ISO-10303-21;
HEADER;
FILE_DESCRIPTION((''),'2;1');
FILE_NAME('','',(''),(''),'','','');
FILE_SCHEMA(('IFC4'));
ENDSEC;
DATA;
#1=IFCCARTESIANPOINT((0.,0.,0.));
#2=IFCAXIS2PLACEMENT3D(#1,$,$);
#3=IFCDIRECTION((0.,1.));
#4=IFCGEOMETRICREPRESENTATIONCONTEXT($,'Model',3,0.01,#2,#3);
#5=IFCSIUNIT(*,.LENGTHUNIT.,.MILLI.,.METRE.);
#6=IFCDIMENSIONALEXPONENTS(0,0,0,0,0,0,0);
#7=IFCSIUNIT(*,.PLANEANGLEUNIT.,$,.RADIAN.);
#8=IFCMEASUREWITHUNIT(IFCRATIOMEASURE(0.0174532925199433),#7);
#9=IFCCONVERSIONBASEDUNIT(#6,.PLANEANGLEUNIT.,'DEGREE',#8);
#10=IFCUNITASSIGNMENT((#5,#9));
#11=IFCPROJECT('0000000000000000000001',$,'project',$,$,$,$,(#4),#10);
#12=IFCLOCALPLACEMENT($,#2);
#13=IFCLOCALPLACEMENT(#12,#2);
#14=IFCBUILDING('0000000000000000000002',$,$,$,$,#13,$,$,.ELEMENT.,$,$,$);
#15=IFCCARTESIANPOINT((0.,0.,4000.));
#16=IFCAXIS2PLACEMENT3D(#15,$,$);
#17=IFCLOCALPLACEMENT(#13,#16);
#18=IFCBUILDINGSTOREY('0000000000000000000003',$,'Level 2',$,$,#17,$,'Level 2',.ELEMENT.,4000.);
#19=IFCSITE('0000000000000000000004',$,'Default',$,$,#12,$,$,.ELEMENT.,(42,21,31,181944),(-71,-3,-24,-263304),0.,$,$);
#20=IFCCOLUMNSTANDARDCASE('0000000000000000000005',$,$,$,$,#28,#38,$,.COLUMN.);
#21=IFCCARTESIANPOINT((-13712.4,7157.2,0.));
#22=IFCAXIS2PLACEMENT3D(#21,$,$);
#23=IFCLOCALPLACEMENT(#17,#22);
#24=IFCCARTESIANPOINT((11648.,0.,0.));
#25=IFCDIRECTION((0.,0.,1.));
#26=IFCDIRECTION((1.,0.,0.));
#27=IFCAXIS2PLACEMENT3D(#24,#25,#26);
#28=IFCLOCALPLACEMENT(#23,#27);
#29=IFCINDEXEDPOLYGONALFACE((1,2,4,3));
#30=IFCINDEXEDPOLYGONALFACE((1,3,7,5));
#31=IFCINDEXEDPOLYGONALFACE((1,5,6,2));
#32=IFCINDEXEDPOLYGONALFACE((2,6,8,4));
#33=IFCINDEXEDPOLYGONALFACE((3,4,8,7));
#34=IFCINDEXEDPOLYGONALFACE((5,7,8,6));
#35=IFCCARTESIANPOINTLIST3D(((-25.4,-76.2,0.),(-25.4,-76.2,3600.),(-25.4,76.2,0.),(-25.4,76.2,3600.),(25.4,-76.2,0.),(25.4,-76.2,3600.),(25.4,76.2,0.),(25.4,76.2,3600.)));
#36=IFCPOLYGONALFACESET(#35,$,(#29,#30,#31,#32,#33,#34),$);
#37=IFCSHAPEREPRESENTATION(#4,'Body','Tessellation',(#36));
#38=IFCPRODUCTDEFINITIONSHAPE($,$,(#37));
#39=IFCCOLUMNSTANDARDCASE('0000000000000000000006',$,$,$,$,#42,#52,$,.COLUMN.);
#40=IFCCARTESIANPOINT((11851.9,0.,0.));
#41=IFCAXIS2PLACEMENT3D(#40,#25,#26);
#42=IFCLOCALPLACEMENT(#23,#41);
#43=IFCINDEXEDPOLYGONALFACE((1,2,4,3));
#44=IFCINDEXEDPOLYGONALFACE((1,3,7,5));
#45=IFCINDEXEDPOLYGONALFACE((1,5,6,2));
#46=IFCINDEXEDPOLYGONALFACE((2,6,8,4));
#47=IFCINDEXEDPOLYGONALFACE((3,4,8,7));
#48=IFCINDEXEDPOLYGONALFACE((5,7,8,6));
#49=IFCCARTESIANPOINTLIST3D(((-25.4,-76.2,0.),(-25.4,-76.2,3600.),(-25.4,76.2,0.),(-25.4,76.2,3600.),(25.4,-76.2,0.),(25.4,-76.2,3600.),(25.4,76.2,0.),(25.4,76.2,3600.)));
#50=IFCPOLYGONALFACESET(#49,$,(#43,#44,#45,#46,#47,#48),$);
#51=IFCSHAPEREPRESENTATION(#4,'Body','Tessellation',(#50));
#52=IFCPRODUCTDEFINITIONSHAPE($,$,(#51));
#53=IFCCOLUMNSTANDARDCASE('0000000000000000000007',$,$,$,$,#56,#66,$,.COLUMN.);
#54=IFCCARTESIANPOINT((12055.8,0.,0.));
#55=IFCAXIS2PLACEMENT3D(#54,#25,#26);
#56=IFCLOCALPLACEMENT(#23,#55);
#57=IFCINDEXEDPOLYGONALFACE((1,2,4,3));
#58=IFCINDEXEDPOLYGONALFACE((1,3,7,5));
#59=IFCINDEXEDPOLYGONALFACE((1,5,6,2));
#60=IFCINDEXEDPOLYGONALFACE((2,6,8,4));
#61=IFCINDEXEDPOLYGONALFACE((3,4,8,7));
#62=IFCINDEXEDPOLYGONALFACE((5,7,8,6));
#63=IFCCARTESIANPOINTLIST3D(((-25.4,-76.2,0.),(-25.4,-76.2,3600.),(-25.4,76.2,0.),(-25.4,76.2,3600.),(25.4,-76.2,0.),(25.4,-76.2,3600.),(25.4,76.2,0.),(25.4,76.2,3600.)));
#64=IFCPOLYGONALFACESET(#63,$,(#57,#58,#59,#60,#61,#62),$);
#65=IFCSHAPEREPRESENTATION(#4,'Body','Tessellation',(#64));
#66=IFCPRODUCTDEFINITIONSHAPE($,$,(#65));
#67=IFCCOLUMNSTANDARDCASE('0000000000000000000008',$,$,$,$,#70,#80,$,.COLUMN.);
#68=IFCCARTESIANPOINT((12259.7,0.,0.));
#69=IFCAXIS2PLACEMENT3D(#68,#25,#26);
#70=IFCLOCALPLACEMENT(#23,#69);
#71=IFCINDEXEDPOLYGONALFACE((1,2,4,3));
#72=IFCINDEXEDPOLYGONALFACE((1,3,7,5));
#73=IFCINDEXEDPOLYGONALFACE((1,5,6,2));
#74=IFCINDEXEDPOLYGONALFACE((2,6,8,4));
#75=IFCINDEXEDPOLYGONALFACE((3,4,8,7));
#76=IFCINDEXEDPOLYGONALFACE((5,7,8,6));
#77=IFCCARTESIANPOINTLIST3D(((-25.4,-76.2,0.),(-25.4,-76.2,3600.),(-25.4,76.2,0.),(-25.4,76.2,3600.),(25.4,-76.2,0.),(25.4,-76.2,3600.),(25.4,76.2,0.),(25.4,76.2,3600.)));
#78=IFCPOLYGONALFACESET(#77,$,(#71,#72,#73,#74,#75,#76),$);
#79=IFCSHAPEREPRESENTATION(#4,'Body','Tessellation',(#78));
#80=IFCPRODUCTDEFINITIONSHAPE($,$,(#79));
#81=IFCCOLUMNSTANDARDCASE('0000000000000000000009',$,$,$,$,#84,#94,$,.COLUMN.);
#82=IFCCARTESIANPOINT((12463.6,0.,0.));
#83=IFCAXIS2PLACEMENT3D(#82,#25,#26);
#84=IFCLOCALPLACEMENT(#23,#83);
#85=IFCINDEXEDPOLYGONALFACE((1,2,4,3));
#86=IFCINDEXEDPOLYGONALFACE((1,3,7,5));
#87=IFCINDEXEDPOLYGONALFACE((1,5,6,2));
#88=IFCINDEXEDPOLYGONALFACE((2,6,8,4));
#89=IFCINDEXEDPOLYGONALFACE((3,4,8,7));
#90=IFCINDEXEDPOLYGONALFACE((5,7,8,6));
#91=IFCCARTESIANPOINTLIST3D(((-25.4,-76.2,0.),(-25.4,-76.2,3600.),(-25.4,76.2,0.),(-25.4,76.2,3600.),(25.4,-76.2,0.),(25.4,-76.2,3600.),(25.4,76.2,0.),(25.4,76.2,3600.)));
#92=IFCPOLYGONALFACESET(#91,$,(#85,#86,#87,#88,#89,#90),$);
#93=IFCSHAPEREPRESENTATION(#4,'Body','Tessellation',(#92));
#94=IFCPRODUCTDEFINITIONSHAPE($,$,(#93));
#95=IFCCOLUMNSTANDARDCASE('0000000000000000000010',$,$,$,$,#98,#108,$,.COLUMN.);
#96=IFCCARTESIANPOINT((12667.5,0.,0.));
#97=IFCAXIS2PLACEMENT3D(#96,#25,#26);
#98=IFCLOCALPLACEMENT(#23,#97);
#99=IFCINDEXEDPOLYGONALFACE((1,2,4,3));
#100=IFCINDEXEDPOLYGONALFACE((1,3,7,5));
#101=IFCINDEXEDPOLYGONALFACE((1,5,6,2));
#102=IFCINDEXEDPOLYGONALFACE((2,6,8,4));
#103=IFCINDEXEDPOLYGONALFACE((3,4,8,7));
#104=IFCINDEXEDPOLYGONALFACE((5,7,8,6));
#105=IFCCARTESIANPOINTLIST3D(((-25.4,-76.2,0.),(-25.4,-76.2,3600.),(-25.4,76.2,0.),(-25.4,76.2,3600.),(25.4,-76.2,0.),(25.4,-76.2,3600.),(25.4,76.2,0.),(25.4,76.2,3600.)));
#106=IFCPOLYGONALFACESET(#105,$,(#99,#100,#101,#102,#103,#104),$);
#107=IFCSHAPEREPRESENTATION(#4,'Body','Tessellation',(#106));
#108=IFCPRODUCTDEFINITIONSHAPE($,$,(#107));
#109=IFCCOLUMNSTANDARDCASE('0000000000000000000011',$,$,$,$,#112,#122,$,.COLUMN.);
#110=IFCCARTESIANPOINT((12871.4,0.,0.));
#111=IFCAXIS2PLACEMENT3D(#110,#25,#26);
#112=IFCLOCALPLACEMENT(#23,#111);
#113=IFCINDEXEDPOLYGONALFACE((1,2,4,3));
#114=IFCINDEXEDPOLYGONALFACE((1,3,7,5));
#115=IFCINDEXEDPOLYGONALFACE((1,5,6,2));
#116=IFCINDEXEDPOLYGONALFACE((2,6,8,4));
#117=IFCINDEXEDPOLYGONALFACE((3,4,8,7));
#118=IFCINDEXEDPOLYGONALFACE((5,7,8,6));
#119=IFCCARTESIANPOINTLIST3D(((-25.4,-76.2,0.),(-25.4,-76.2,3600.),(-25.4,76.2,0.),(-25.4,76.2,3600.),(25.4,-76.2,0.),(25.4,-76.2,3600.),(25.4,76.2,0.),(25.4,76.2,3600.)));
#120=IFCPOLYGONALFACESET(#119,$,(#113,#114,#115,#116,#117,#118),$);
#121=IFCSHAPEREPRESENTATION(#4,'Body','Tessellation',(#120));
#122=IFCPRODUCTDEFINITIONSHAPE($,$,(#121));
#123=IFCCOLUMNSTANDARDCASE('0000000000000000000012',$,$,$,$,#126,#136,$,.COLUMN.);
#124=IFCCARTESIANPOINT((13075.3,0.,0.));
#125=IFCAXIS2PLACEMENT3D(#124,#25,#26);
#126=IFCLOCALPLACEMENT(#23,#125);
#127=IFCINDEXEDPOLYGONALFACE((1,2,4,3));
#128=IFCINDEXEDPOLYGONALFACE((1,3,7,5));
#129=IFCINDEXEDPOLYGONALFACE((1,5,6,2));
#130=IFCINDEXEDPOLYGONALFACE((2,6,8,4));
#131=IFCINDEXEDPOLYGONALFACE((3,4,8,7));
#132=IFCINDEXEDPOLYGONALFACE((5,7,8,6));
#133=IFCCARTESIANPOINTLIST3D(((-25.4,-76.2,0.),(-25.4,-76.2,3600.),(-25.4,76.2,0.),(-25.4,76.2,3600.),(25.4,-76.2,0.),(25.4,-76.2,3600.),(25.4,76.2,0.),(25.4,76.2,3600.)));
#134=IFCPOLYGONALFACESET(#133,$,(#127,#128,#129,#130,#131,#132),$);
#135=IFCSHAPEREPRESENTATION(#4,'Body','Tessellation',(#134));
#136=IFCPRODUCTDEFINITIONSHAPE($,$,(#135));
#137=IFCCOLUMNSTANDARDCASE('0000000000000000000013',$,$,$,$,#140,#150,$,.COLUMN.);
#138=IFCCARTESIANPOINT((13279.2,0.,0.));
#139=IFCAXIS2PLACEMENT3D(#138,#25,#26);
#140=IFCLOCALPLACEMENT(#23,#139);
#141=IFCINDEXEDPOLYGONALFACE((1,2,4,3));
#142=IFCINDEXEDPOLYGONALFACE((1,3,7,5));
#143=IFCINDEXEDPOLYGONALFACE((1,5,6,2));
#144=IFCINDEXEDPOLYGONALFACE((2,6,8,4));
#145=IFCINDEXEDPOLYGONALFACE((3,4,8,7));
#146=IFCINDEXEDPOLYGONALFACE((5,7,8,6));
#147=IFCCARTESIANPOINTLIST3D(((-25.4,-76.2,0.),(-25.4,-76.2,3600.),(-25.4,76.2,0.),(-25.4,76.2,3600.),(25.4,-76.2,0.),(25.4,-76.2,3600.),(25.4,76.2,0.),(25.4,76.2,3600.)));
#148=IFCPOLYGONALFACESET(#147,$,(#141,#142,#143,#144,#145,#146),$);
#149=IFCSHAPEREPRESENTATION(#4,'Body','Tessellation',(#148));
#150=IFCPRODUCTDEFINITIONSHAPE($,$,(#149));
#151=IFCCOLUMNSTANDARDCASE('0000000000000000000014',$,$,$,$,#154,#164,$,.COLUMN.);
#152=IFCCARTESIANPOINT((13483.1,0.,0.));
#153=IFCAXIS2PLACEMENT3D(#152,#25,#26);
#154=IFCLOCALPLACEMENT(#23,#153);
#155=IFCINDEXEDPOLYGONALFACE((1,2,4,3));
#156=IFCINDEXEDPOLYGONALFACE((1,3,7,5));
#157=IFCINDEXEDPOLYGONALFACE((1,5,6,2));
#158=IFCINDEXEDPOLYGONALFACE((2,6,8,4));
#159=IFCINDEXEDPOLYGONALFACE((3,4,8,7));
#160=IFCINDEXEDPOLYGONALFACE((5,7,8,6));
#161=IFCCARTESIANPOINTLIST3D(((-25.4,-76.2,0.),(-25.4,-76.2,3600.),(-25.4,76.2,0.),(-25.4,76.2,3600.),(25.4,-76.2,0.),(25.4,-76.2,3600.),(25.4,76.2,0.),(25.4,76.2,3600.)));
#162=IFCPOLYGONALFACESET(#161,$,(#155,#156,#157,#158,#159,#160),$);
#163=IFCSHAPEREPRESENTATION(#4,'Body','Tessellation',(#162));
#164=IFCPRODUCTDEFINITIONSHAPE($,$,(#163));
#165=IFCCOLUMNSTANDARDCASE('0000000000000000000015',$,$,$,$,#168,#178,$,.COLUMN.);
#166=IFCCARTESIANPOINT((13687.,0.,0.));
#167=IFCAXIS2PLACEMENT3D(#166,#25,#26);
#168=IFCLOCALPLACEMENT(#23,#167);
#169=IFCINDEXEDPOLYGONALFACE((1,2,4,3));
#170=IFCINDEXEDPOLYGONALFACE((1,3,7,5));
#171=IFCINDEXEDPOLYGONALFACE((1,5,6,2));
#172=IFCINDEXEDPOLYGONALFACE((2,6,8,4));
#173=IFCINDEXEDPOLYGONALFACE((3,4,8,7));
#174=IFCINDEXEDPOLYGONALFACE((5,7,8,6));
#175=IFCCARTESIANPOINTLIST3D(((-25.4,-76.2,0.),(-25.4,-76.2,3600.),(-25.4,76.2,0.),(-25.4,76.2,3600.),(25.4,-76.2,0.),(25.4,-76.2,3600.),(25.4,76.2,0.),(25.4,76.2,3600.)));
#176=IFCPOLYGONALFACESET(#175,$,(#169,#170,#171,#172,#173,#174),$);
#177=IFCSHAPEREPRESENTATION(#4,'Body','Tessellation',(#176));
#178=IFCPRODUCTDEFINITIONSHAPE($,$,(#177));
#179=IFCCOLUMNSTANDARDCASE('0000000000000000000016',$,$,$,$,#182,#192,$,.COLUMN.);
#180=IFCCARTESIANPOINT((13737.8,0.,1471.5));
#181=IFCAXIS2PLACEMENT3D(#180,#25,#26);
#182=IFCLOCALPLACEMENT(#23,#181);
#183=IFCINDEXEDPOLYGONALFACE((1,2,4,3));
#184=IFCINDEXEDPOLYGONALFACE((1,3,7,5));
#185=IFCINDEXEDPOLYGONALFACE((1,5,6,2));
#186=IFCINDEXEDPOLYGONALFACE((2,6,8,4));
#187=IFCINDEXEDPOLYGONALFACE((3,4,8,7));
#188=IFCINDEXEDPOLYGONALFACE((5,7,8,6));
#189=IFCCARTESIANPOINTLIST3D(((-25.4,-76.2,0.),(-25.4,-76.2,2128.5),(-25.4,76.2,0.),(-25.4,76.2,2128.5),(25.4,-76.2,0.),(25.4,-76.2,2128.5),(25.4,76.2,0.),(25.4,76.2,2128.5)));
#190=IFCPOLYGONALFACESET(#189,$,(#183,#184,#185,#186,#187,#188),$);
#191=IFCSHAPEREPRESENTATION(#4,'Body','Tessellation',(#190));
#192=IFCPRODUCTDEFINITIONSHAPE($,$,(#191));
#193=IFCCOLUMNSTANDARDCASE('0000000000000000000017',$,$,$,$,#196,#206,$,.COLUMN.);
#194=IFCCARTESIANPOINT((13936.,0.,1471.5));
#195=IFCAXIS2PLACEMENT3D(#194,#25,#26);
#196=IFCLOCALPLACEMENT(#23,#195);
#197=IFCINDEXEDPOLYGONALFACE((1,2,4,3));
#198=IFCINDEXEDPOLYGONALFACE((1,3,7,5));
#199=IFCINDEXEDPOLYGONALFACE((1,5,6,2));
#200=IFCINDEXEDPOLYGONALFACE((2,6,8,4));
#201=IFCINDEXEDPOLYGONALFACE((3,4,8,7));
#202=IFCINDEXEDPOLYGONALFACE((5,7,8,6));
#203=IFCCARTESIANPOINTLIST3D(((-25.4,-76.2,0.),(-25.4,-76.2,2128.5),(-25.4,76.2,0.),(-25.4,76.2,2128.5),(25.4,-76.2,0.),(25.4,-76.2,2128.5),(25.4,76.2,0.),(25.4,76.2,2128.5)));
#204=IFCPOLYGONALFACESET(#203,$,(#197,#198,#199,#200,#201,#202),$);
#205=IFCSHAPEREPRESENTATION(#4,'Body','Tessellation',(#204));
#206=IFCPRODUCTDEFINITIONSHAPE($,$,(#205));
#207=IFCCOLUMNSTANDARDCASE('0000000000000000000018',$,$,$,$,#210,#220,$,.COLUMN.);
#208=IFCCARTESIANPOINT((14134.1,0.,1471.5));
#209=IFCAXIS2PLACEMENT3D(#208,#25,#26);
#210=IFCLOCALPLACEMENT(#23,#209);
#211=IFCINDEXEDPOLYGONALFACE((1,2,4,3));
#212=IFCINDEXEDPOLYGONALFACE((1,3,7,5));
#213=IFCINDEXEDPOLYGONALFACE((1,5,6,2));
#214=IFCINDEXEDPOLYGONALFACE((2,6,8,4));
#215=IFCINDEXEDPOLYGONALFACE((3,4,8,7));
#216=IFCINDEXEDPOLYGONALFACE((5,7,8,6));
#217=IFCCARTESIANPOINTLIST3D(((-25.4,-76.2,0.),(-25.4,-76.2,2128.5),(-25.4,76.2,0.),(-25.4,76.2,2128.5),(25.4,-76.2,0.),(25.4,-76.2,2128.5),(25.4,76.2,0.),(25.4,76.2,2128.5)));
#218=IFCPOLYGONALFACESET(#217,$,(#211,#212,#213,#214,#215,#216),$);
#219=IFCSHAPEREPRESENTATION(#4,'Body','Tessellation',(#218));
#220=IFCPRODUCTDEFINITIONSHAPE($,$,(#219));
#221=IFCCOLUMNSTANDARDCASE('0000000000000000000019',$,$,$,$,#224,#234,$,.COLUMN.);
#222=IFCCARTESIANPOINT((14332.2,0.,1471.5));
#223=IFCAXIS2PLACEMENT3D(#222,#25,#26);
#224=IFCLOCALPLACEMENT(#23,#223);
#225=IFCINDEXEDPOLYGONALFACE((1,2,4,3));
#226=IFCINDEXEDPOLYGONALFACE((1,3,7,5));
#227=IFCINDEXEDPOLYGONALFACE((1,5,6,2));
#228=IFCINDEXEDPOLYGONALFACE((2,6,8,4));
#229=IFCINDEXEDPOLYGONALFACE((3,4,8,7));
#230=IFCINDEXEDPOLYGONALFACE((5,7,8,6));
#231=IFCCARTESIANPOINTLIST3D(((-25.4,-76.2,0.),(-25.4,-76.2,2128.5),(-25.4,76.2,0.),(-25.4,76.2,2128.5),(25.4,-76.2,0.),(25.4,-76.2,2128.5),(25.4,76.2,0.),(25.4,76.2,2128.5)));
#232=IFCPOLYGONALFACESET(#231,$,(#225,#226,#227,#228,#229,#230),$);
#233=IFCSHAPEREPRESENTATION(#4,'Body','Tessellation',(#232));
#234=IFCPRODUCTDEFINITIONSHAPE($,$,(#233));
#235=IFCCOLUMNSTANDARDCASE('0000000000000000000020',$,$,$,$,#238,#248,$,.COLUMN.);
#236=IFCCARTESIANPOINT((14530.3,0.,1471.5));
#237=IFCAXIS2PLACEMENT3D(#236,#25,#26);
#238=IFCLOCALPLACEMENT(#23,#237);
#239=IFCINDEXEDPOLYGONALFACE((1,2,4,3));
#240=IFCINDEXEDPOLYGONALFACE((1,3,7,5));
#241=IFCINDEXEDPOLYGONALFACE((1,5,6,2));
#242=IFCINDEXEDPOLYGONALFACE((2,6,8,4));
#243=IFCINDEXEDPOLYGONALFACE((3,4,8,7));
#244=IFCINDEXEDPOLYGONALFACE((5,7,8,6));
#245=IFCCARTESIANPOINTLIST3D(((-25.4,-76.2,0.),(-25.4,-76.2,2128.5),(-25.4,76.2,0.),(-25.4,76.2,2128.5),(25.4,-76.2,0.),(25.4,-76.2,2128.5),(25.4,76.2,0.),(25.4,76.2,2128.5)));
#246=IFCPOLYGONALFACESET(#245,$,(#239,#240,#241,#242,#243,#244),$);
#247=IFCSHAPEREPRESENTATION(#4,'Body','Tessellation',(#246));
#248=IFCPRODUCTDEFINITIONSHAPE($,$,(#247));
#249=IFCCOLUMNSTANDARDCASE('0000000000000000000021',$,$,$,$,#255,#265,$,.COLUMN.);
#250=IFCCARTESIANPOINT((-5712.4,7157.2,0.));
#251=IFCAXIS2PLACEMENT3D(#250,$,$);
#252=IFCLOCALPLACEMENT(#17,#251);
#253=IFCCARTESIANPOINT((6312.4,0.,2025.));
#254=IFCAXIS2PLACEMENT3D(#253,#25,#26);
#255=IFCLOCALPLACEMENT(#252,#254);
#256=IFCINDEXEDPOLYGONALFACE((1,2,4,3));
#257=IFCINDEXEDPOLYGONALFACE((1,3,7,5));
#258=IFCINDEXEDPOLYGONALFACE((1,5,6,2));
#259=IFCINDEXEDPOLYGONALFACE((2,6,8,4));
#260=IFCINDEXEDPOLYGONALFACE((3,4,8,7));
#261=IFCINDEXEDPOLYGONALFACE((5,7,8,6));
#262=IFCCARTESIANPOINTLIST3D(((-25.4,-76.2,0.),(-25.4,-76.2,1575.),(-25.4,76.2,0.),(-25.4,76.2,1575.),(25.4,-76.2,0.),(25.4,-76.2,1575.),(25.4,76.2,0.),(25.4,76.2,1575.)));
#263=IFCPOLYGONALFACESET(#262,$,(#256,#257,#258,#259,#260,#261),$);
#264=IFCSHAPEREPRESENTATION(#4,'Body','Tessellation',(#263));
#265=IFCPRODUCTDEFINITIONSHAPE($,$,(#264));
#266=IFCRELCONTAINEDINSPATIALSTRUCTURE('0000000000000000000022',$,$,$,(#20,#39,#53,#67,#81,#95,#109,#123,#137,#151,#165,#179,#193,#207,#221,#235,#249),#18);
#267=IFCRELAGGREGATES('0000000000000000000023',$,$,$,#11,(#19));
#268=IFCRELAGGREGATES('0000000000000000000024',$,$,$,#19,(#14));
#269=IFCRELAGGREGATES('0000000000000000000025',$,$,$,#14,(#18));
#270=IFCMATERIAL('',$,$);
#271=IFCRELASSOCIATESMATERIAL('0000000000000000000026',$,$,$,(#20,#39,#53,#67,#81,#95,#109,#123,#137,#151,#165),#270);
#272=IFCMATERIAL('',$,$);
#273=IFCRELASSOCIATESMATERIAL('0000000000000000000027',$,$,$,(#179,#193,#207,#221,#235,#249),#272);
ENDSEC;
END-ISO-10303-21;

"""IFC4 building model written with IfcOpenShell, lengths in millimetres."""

from ifc_helpers import new_model, entity, si_unit, converted_unit, direction, frame, origin, place, context, project, spatial, rectangle, extrude, material, element, save


model = new_model("IFC4")

# Units and contexts
model_context = context("Model", 3, precision=0.01, world=origin(), true_north=direction((0.0, 1.0)))
ifc_project = project(units=[si_unit("LENGTHUNIT", "METRE", prefix="MILLI"), converted_unit("PLANEANGLEUNIT", "DEGREE", entity("IfcRatioMeasure", 0.0174532925199433), si_unit("PLANEANGLEUNIT", "RADIAN"), dimensions=[0, 0, 0, 0, 0, 0, 0])], contexts=[model_context])

# Site, building, storey
site_placement = place(None, origin())
site = spatial("IfcSite", under=ifc_project, at=site_placement, Name="Default", CompositionType="ELEMENT", RefLatitude=(42, 21, 31, 181944), RefLongitude=(-71, -3, -24, -263304), RefElevation=0.0)
building_placement = place(site_placement, origin())
building = spatial("IfcBuilding", under=site, at=building_placement, CompositionType="ELEMENT")
storey_placement = place(building_placement, frame((0.0, 0.0, 4000.0)))
storey = spatial("IfcBuildingStorey", under=building, at=storey_placement, Name="Level 2", LongName="Level 2", CompositionType="ELEMENT", Elevation=4000.0)

# Columns
ifc_material_1 = material(Name="")
placement_1 = place(storey_placement, frame((-13712.4, 7157.2, 0.0)))
for number, where, z_axis, x_axis in (
    (1, (11648.0, 0.0, 0.0), (0.0, 0.0, 1.0), (1.0, 0.0, 0.0)),
    (2, (11851.9, 0.0, 0.0), (0.0, 0.0, 1.0), (1.0, 0.0, 0.0)),
    (3, (12055.8, 0.0, 0.0), (0.0, 0.0, 1.0), (1.0, 0.0, 0.0)),
    (4, (12259.7, 0.0, 0.0), (0.0, 0.0, 1.0), (1.0, 0.0, 0.0)),
    (5, (12463.6, 0.0, 0.0), (0.0, 0.0, 1.0), (1.0, 0.0, 0.0)),
    (6, (12667.5, 0.0, 0.0), (0.0, 0.0, 1.0), (1.0, 0.0, 0.0)),
    (7, (12871.4, 0.0, 0.0), (0.0, 0.0, 1.0), (1.0, 0.0, 0.0)),
    (8, (13075.3, 0.0, 0.0), (0.0, 0.0, 1.0), (1.0, 0.0, 0.0)),
    (9, (13279.2, 0.0, 0.0), (0.0, 0.0, 1.0), (1.0, 0.0, 0.0)),
    (10, (13483.1, 0.0, 0.0), (0.0, 0.0, 1.0), (1.0, 0.0, 0.0)),
    (11, (13687.0, 0.0, 0.0), (0.0, 0.0, 1.0), (1.0, 0.0, 0.0)),
):
    element("IfcColumnStandardCase", number, at=place(placement_1, frame(where, z_axis=z_axis, x_axis=x_axis)), inside=storey, material=ifc_material_1, PredefinedType="COLUMN", context=model_context, shape_type="SweptSolid", body=[
        extrude(rectangle(XDim=50.8, YDim=152.4), origin(), (0.0, 0.0, 1.0), 3600.0),
    ])
ifc_material_2 = material(Name="")
for number, where, z_axis, x_axis in (
    (12, (13737.8, 0.0, 1471.5), (0.0, 0.0, 1.0), (1.0, 0.0, 0.0)),
    (13, (13936.0, 0.0, 1471.5), (0.0, 0.0, 1.0), (1.0, 0.0, 0.0)),
    (14, (14134.1, 0.0, 1471.5), (0.0, 0.0, 1.0), (1.0, 0.0, 0.0)),
    (15, (14332.2, 0.0, 1471.5), (0.0, 0.0, 1.0), (1.0, 0.0, 0.0)),
    (16, (14530.3, 0.0, 1471.5), (0.0, 0.0, 1.0), (1.0, 0.0, 0.0)),
):
    element("IfcColumnStandardCase", number, at=place(placement_1, frame(where, z_axis=z_axis, x_axis=x_axis)), inside=storey, material=ifc_material_2, PredefinedType="COLUMN", context=model_context, shape_type="SweptSolid", body=[
        extrude(rectangle(XDim=50.8, YDim=152.4), origin(), (0.0, 0.0, 1.0), 2128.5),
    ])
placement_2 = place(storey_placement, frame((-5712.4, 7157.2, 0.0)))
for number, where, z_axis, x_axis in (
    (17, (6312.4, 0.0, 2025.0), (0.0, 0.0, 1.0), (1.0, 0.0, 0.0)),
):
    element("IfcColumnStandardCase", number, at=place(placement_2, frame(where, z_axis=z_axis, x_axis=x_axis)), inside=storey, material=ifc_material_2, PredefinedType="COLUMN", context=model_context, shape_type="SweptSolid", body=[
        extrude(rectangle(XDim=50.8, YDim=152.4), origin(), (0.0, 0.0, 1.0), 1575.0),
    ])

save(model, "model.ifc")
